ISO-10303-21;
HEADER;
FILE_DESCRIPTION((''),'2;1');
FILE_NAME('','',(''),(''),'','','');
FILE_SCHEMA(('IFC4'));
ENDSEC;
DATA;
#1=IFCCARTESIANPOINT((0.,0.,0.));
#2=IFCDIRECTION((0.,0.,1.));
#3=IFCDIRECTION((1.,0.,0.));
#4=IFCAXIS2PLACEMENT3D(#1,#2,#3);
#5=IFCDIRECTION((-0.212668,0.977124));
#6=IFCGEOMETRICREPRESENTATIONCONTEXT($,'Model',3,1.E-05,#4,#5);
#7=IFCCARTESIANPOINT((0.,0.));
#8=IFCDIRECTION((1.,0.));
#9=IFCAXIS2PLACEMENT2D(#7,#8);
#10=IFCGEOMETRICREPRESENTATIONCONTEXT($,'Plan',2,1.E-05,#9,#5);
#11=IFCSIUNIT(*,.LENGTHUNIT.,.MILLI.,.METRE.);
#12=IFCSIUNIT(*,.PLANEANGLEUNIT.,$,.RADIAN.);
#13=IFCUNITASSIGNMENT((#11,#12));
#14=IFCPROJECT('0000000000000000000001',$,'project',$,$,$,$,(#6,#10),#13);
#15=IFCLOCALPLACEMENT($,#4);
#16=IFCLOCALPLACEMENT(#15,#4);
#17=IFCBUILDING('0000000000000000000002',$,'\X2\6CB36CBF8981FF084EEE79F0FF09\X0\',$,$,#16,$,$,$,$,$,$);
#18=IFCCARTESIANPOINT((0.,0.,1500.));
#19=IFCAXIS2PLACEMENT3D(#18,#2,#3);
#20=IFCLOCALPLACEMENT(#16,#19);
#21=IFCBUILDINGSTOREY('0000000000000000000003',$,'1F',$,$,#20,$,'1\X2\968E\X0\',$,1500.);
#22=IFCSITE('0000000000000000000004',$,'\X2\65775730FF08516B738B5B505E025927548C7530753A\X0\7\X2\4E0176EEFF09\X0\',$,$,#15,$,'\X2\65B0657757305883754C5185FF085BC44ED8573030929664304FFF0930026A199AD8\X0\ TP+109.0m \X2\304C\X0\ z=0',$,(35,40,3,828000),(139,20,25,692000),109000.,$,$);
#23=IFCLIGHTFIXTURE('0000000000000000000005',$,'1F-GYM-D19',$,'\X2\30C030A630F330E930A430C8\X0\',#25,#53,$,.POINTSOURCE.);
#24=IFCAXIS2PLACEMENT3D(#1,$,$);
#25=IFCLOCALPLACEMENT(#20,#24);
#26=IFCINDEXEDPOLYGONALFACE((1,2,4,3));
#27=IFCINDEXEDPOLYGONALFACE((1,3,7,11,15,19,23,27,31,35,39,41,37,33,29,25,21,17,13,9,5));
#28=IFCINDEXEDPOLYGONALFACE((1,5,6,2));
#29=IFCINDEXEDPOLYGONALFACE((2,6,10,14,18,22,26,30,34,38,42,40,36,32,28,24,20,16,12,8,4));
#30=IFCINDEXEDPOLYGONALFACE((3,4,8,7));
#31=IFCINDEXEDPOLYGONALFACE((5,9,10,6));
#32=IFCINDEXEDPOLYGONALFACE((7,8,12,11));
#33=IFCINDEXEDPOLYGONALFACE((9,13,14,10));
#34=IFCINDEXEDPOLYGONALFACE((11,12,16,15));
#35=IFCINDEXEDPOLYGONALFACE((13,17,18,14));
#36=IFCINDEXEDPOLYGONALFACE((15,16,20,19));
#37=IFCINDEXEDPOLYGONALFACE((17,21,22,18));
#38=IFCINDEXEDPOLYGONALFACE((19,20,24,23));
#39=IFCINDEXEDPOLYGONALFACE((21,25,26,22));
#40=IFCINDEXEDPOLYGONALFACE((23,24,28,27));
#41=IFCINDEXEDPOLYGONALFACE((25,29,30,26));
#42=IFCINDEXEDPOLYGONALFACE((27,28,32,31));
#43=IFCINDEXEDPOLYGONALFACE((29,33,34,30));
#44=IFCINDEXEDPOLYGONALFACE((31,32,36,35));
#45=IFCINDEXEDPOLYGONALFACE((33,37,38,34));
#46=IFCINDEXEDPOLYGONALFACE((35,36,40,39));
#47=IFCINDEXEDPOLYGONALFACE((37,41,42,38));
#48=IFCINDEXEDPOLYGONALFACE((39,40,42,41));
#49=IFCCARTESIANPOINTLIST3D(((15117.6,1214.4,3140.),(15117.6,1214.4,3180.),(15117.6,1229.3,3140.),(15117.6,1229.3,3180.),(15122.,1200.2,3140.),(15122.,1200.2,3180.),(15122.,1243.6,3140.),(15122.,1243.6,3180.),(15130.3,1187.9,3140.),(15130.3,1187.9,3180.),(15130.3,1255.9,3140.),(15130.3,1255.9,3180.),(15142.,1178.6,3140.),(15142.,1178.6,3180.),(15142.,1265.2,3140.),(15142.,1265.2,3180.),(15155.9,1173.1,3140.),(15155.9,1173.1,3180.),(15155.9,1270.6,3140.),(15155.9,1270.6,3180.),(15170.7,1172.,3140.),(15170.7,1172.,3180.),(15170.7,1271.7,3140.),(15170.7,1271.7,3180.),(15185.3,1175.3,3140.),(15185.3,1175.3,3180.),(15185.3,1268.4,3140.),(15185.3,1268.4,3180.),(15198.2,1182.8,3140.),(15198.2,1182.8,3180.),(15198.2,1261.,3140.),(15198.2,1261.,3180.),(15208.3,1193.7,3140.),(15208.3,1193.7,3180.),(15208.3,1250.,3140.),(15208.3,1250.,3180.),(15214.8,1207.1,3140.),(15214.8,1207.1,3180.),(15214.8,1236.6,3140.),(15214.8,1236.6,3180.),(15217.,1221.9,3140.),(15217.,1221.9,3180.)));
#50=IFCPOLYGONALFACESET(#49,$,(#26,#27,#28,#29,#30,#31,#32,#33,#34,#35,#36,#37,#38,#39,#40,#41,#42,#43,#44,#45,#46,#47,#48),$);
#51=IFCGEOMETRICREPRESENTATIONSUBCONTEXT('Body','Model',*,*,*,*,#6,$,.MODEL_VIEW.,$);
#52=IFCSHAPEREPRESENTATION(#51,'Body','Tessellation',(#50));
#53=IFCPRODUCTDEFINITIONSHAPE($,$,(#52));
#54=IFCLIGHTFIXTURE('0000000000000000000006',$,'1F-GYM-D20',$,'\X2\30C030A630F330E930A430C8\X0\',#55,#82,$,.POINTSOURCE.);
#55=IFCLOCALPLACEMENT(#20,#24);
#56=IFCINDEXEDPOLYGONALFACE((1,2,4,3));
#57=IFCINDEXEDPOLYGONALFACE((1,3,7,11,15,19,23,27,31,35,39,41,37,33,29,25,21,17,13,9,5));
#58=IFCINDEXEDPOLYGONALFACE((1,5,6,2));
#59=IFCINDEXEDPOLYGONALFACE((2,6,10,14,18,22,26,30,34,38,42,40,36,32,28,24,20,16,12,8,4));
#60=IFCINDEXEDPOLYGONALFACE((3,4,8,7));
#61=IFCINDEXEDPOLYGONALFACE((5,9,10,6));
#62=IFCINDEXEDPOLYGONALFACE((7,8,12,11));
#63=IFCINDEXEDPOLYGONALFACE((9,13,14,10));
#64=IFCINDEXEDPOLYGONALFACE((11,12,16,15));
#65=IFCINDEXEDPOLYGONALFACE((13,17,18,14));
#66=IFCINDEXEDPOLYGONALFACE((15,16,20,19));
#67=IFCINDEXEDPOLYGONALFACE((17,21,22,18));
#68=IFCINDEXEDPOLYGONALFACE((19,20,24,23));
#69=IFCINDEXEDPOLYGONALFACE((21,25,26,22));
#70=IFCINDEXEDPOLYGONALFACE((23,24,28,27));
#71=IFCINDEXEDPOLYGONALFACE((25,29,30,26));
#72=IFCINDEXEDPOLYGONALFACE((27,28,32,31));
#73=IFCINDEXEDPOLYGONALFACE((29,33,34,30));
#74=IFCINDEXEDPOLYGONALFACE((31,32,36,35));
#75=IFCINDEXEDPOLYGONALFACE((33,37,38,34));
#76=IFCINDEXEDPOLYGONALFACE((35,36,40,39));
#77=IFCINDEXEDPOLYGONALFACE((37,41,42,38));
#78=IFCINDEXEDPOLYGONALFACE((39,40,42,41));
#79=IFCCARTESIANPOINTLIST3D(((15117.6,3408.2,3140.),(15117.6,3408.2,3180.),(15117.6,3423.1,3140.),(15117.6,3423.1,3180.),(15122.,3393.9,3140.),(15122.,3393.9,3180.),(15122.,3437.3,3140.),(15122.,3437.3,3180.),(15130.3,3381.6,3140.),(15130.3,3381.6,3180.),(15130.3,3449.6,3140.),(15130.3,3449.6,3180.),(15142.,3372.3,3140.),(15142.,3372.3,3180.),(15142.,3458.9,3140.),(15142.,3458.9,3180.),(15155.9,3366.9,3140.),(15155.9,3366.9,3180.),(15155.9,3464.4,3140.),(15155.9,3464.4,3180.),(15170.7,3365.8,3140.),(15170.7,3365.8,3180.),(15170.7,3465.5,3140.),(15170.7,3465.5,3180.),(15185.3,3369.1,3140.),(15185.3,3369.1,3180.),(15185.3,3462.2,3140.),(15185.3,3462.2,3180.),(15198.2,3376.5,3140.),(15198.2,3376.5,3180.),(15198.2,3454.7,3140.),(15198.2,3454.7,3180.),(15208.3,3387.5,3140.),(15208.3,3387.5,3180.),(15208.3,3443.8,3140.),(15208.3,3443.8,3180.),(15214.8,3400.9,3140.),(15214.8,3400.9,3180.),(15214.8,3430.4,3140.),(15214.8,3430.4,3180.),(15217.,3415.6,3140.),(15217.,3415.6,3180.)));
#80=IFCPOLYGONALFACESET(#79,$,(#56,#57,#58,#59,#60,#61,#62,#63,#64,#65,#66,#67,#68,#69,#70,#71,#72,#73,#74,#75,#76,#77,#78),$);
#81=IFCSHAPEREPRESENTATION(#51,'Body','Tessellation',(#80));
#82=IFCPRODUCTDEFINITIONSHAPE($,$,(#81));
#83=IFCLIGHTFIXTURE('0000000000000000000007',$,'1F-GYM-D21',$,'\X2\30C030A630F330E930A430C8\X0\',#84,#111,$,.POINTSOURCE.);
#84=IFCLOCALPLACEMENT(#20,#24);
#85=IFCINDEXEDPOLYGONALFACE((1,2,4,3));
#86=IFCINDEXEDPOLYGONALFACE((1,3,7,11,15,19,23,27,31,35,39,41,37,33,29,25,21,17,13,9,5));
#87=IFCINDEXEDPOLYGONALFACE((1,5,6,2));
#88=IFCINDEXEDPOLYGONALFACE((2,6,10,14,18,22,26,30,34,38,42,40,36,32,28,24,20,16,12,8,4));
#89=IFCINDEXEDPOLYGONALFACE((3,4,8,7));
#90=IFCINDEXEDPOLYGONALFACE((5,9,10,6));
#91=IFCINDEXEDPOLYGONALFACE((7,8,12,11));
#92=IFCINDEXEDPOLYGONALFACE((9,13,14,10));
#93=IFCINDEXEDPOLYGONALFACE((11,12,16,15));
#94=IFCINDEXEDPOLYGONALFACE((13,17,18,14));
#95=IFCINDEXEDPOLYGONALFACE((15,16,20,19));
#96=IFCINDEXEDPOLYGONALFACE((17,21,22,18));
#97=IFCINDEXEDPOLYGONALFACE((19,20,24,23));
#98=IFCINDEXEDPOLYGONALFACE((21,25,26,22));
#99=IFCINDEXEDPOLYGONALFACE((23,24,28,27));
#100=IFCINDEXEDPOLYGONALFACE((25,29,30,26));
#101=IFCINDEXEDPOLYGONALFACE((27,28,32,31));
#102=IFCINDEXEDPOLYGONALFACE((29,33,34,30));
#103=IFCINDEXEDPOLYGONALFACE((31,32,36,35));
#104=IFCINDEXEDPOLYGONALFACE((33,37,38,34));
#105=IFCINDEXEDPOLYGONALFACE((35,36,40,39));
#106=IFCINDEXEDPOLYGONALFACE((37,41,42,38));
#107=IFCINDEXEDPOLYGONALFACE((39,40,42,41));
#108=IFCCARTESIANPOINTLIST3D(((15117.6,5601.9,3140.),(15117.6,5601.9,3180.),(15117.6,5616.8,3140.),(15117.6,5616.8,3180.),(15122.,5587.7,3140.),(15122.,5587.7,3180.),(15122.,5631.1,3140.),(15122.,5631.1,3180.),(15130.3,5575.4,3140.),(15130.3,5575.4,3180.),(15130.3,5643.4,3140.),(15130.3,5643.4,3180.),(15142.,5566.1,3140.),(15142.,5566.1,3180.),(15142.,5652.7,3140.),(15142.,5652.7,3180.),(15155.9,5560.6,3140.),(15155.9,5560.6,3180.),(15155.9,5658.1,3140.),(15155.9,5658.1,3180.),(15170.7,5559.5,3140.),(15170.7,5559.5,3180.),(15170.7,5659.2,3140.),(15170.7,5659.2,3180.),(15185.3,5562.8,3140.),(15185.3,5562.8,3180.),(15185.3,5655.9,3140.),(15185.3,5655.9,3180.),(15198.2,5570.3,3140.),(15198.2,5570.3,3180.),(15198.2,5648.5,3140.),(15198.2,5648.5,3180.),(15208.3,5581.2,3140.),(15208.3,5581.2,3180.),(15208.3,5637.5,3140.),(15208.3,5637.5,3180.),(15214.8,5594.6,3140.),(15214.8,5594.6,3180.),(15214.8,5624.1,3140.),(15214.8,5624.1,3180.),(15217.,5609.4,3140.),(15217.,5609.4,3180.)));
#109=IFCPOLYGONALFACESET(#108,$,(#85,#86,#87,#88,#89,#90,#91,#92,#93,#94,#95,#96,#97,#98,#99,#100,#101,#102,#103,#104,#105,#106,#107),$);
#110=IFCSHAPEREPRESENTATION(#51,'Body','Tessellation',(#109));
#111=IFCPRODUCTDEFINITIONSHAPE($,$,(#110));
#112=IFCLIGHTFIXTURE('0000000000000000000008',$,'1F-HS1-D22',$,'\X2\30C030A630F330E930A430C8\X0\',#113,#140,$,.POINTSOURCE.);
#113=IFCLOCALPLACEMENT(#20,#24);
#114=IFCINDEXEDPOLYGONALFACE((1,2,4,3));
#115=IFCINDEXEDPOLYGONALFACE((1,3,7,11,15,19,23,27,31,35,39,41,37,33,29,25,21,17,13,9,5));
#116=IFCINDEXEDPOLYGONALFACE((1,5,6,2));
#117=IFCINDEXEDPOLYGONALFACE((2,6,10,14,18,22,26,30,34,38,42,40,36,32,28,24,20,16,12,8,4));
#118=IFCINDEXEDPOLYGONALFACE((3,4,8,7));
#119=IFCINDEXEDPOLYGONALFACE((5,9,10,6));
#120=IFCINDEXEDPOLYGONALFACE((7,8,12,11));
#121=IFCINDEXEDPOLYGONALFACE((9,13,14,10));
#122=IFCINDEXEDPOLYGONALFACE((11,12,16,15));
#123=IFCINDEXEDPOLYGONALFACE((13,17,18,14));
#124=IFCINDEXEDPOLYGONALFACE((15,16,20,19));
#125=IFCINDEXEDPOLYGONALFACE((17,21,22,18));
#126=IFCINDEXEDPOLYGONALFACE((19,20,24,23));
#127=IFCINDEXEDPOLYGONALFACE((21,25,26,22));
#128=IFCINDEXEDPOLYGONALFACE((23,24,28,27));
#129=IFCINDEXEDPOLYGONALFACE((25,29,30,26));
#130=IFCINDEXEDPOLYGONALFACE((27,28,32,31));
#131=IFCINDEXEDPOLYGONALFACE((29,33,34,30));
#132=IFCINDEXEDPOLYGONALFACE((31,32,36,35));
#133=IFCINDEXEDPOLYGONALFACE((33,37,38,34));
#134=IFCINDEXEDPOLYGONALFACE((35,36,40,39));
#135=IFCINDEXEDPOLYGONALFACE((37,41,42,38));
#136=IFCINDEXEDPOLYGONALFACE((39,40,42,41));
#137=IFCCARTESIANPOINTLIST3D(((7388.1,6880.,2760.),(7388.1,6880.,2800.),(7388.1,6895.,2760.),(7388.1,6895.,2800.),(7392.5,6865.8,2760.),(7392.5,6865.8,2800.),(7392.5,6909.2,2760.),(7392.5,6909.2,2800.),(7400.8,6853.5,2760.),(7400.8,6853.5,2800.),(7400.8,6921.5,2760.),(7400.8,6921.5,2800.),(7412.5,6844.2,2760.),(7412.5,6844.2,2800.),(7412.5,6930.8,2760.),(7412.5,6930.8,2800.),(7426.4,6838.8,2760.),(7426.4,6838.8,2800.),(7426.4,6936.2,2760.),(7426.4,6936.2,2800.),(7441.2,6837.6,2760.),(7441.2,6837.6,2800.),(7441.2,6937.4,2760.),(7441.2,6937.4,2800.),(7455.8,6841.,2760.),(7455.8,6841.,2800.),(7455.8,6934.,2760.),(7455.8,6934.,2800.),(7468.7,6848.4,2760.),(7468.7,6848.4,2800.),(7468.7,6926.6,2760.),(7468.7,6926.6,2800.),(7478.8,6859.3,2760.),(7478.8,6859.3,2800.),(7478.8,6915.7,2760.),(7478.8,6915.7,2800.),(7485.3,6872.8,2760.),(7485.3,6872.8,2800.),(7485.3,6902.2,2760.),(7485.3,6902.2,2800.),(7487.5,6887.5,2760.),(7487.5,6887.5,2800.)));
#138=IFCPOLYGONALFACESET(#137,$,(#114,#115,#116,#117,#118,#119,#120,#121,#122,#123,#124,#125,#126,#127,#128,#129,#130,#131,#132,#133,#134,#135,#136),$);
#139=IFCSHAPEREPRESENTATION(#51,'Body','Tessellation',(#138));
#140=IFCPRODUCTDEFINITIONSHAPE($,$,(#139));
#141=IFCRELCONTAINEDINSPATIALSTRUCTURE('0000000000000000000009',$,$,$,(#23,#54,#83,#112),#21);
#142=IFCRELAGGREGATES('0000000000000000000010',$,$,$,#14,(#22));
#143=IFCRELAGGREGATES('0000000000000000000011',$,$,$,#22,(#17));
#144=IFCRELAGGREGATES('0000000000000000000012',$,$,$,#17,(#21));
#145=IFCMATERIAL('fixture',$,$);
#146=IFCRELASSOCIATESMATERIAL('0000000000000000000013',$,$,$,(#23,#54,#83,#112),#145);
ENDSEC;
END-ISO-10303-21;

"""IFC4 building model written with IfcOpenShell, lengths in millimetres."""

from ifc_helpers import new_model, si_unit, direction, frame, frame_2d, origin_with_axes, origin_2d_with_axis, place, context, subcontext, project, spatial, circle, extrude, material, element, save


model = new_model("IFC4")

# Units and contexts
model_context = context("Model", 3, precision=1e-05, world=origin_with_axes(), true_north=direction((-0.212668, 0.977124)))
plan_context = context("Plan", 2, precision=1e-05, world=origin_2d_with_axis(), true_north=direction((-0.212668, 0.977124)))
body_context = subcontext(model_context, "Body", "Model", "MODEL_VIEW")
ifc_project = project(units=[si_unit("LENGTHUNIT", "METRE", prefix="MILLI"), si_unit("PLANEANGLEUNIT", "RADIAN")], contexts=[model_context, plan_context])

# Site, building, storey
site_placement = place(None, origin_with_axes())
site = spatial("IfcSite", under=ifc_project, at=site_placement, Name="敷地（八王子市大和田町7丁目）", LongName="新敷地境界内（寄付地を除く）。標高 TP+109.0m が z=0", RefLatitude=(35, 40, 3, 828000), RefLongitude=(139, 20, 25, 692000), RefElevation=109000.0)
building_placement = place(site_placement, origin_with_axes())
building = spatial("IfcBuilding", under=site, at=building_placement, Name="河沿要（仮称）")
storey_placement = place(building_placement, frame((0.0, 0.0, 1500.0), z_axis=(0.0, 0.0, 1.0), x_axis=(1.0, 0.0, 0.0)))
storey = spatial("IfcBuildingStorey", under=building, at=storey_placement, Name="1F", LongName="1階", Elevation=1500.0)

# Light fixtures
ifc_material = material(Name="fixture")
light_fixture_1_placement = place(storey_placement, origin_with_axes())
element("IfcLightFixture", 1, at=light_fixture_1_placement, inside=storey, material=ifc_material, Name="1F-GYM-D19", ObjectType="ダウンライト", PredefinedType="POINTSOURCE", context=body_context, shape_type="SweptSolid", body=[
    extrude(circle(Radius=50.0, at=frame_2d((15167.0, 1221.9))), frame((0.0, 0.0, 3140.0)), (0.0, 0.0, 1.0), 40.0),
])
light_fixture_2_placement = place(storey_placement, origin_with_axes())
element("IfcLightFixture", 2, at=light_fixture_2_placement, inside=storey, material=ifc_material, Name="1F-GYM-D20", ObjectType="ダウンライト", PredefinedType="POINTSOURCE", context=body_context, shape_type="SweptSolid", body=[
    extrude(circle(Radius=50.0, at=frame_2d((15167.0, 3415.6))), frame((0.0, 0.0, 3140.0)), (0.0, 0.0, 1.0), 40.0),
])
light_fixture_3_placement = place(storey_placement, origin_with_axes())
element("IfcLightFixture", 3, at=light_fixture_3_placement, inside=storey, material=ifc_material, Name="1F-GYM-D21", ObjectType="ダウンライト", PredefinedType="POINTSOURCE", context=body_context, shape_type="SweptSolid", body=[
    extrude(circle(Radius=50.0, at=frame_2d((15167.0, 5609.4))), frame((0.0, 0.0, 3140.0)), (0.0, 0.0, 1.0), 40.0),
])
light_fixture_4_placement = place(storey_placement, origin_with_axes())
element("IfcLightFixture", 4, at=light_fixture_4_placement, inside=storey, material=ifc_material, Name="1F-HS1-D22", ObjectType="ダウンライト", PredefinedType="POINTSOURCE", context=body_context, shape_type="SweptSolid", body=[
    extrude(circle(Radius=50.0, at=frame_2d((7437.5, 6887.5))), frame((0.0, 0.0, 2760.0)), (0.0, 0.0, 1.0), 40.0),
])

save(model, "model.ifc")
